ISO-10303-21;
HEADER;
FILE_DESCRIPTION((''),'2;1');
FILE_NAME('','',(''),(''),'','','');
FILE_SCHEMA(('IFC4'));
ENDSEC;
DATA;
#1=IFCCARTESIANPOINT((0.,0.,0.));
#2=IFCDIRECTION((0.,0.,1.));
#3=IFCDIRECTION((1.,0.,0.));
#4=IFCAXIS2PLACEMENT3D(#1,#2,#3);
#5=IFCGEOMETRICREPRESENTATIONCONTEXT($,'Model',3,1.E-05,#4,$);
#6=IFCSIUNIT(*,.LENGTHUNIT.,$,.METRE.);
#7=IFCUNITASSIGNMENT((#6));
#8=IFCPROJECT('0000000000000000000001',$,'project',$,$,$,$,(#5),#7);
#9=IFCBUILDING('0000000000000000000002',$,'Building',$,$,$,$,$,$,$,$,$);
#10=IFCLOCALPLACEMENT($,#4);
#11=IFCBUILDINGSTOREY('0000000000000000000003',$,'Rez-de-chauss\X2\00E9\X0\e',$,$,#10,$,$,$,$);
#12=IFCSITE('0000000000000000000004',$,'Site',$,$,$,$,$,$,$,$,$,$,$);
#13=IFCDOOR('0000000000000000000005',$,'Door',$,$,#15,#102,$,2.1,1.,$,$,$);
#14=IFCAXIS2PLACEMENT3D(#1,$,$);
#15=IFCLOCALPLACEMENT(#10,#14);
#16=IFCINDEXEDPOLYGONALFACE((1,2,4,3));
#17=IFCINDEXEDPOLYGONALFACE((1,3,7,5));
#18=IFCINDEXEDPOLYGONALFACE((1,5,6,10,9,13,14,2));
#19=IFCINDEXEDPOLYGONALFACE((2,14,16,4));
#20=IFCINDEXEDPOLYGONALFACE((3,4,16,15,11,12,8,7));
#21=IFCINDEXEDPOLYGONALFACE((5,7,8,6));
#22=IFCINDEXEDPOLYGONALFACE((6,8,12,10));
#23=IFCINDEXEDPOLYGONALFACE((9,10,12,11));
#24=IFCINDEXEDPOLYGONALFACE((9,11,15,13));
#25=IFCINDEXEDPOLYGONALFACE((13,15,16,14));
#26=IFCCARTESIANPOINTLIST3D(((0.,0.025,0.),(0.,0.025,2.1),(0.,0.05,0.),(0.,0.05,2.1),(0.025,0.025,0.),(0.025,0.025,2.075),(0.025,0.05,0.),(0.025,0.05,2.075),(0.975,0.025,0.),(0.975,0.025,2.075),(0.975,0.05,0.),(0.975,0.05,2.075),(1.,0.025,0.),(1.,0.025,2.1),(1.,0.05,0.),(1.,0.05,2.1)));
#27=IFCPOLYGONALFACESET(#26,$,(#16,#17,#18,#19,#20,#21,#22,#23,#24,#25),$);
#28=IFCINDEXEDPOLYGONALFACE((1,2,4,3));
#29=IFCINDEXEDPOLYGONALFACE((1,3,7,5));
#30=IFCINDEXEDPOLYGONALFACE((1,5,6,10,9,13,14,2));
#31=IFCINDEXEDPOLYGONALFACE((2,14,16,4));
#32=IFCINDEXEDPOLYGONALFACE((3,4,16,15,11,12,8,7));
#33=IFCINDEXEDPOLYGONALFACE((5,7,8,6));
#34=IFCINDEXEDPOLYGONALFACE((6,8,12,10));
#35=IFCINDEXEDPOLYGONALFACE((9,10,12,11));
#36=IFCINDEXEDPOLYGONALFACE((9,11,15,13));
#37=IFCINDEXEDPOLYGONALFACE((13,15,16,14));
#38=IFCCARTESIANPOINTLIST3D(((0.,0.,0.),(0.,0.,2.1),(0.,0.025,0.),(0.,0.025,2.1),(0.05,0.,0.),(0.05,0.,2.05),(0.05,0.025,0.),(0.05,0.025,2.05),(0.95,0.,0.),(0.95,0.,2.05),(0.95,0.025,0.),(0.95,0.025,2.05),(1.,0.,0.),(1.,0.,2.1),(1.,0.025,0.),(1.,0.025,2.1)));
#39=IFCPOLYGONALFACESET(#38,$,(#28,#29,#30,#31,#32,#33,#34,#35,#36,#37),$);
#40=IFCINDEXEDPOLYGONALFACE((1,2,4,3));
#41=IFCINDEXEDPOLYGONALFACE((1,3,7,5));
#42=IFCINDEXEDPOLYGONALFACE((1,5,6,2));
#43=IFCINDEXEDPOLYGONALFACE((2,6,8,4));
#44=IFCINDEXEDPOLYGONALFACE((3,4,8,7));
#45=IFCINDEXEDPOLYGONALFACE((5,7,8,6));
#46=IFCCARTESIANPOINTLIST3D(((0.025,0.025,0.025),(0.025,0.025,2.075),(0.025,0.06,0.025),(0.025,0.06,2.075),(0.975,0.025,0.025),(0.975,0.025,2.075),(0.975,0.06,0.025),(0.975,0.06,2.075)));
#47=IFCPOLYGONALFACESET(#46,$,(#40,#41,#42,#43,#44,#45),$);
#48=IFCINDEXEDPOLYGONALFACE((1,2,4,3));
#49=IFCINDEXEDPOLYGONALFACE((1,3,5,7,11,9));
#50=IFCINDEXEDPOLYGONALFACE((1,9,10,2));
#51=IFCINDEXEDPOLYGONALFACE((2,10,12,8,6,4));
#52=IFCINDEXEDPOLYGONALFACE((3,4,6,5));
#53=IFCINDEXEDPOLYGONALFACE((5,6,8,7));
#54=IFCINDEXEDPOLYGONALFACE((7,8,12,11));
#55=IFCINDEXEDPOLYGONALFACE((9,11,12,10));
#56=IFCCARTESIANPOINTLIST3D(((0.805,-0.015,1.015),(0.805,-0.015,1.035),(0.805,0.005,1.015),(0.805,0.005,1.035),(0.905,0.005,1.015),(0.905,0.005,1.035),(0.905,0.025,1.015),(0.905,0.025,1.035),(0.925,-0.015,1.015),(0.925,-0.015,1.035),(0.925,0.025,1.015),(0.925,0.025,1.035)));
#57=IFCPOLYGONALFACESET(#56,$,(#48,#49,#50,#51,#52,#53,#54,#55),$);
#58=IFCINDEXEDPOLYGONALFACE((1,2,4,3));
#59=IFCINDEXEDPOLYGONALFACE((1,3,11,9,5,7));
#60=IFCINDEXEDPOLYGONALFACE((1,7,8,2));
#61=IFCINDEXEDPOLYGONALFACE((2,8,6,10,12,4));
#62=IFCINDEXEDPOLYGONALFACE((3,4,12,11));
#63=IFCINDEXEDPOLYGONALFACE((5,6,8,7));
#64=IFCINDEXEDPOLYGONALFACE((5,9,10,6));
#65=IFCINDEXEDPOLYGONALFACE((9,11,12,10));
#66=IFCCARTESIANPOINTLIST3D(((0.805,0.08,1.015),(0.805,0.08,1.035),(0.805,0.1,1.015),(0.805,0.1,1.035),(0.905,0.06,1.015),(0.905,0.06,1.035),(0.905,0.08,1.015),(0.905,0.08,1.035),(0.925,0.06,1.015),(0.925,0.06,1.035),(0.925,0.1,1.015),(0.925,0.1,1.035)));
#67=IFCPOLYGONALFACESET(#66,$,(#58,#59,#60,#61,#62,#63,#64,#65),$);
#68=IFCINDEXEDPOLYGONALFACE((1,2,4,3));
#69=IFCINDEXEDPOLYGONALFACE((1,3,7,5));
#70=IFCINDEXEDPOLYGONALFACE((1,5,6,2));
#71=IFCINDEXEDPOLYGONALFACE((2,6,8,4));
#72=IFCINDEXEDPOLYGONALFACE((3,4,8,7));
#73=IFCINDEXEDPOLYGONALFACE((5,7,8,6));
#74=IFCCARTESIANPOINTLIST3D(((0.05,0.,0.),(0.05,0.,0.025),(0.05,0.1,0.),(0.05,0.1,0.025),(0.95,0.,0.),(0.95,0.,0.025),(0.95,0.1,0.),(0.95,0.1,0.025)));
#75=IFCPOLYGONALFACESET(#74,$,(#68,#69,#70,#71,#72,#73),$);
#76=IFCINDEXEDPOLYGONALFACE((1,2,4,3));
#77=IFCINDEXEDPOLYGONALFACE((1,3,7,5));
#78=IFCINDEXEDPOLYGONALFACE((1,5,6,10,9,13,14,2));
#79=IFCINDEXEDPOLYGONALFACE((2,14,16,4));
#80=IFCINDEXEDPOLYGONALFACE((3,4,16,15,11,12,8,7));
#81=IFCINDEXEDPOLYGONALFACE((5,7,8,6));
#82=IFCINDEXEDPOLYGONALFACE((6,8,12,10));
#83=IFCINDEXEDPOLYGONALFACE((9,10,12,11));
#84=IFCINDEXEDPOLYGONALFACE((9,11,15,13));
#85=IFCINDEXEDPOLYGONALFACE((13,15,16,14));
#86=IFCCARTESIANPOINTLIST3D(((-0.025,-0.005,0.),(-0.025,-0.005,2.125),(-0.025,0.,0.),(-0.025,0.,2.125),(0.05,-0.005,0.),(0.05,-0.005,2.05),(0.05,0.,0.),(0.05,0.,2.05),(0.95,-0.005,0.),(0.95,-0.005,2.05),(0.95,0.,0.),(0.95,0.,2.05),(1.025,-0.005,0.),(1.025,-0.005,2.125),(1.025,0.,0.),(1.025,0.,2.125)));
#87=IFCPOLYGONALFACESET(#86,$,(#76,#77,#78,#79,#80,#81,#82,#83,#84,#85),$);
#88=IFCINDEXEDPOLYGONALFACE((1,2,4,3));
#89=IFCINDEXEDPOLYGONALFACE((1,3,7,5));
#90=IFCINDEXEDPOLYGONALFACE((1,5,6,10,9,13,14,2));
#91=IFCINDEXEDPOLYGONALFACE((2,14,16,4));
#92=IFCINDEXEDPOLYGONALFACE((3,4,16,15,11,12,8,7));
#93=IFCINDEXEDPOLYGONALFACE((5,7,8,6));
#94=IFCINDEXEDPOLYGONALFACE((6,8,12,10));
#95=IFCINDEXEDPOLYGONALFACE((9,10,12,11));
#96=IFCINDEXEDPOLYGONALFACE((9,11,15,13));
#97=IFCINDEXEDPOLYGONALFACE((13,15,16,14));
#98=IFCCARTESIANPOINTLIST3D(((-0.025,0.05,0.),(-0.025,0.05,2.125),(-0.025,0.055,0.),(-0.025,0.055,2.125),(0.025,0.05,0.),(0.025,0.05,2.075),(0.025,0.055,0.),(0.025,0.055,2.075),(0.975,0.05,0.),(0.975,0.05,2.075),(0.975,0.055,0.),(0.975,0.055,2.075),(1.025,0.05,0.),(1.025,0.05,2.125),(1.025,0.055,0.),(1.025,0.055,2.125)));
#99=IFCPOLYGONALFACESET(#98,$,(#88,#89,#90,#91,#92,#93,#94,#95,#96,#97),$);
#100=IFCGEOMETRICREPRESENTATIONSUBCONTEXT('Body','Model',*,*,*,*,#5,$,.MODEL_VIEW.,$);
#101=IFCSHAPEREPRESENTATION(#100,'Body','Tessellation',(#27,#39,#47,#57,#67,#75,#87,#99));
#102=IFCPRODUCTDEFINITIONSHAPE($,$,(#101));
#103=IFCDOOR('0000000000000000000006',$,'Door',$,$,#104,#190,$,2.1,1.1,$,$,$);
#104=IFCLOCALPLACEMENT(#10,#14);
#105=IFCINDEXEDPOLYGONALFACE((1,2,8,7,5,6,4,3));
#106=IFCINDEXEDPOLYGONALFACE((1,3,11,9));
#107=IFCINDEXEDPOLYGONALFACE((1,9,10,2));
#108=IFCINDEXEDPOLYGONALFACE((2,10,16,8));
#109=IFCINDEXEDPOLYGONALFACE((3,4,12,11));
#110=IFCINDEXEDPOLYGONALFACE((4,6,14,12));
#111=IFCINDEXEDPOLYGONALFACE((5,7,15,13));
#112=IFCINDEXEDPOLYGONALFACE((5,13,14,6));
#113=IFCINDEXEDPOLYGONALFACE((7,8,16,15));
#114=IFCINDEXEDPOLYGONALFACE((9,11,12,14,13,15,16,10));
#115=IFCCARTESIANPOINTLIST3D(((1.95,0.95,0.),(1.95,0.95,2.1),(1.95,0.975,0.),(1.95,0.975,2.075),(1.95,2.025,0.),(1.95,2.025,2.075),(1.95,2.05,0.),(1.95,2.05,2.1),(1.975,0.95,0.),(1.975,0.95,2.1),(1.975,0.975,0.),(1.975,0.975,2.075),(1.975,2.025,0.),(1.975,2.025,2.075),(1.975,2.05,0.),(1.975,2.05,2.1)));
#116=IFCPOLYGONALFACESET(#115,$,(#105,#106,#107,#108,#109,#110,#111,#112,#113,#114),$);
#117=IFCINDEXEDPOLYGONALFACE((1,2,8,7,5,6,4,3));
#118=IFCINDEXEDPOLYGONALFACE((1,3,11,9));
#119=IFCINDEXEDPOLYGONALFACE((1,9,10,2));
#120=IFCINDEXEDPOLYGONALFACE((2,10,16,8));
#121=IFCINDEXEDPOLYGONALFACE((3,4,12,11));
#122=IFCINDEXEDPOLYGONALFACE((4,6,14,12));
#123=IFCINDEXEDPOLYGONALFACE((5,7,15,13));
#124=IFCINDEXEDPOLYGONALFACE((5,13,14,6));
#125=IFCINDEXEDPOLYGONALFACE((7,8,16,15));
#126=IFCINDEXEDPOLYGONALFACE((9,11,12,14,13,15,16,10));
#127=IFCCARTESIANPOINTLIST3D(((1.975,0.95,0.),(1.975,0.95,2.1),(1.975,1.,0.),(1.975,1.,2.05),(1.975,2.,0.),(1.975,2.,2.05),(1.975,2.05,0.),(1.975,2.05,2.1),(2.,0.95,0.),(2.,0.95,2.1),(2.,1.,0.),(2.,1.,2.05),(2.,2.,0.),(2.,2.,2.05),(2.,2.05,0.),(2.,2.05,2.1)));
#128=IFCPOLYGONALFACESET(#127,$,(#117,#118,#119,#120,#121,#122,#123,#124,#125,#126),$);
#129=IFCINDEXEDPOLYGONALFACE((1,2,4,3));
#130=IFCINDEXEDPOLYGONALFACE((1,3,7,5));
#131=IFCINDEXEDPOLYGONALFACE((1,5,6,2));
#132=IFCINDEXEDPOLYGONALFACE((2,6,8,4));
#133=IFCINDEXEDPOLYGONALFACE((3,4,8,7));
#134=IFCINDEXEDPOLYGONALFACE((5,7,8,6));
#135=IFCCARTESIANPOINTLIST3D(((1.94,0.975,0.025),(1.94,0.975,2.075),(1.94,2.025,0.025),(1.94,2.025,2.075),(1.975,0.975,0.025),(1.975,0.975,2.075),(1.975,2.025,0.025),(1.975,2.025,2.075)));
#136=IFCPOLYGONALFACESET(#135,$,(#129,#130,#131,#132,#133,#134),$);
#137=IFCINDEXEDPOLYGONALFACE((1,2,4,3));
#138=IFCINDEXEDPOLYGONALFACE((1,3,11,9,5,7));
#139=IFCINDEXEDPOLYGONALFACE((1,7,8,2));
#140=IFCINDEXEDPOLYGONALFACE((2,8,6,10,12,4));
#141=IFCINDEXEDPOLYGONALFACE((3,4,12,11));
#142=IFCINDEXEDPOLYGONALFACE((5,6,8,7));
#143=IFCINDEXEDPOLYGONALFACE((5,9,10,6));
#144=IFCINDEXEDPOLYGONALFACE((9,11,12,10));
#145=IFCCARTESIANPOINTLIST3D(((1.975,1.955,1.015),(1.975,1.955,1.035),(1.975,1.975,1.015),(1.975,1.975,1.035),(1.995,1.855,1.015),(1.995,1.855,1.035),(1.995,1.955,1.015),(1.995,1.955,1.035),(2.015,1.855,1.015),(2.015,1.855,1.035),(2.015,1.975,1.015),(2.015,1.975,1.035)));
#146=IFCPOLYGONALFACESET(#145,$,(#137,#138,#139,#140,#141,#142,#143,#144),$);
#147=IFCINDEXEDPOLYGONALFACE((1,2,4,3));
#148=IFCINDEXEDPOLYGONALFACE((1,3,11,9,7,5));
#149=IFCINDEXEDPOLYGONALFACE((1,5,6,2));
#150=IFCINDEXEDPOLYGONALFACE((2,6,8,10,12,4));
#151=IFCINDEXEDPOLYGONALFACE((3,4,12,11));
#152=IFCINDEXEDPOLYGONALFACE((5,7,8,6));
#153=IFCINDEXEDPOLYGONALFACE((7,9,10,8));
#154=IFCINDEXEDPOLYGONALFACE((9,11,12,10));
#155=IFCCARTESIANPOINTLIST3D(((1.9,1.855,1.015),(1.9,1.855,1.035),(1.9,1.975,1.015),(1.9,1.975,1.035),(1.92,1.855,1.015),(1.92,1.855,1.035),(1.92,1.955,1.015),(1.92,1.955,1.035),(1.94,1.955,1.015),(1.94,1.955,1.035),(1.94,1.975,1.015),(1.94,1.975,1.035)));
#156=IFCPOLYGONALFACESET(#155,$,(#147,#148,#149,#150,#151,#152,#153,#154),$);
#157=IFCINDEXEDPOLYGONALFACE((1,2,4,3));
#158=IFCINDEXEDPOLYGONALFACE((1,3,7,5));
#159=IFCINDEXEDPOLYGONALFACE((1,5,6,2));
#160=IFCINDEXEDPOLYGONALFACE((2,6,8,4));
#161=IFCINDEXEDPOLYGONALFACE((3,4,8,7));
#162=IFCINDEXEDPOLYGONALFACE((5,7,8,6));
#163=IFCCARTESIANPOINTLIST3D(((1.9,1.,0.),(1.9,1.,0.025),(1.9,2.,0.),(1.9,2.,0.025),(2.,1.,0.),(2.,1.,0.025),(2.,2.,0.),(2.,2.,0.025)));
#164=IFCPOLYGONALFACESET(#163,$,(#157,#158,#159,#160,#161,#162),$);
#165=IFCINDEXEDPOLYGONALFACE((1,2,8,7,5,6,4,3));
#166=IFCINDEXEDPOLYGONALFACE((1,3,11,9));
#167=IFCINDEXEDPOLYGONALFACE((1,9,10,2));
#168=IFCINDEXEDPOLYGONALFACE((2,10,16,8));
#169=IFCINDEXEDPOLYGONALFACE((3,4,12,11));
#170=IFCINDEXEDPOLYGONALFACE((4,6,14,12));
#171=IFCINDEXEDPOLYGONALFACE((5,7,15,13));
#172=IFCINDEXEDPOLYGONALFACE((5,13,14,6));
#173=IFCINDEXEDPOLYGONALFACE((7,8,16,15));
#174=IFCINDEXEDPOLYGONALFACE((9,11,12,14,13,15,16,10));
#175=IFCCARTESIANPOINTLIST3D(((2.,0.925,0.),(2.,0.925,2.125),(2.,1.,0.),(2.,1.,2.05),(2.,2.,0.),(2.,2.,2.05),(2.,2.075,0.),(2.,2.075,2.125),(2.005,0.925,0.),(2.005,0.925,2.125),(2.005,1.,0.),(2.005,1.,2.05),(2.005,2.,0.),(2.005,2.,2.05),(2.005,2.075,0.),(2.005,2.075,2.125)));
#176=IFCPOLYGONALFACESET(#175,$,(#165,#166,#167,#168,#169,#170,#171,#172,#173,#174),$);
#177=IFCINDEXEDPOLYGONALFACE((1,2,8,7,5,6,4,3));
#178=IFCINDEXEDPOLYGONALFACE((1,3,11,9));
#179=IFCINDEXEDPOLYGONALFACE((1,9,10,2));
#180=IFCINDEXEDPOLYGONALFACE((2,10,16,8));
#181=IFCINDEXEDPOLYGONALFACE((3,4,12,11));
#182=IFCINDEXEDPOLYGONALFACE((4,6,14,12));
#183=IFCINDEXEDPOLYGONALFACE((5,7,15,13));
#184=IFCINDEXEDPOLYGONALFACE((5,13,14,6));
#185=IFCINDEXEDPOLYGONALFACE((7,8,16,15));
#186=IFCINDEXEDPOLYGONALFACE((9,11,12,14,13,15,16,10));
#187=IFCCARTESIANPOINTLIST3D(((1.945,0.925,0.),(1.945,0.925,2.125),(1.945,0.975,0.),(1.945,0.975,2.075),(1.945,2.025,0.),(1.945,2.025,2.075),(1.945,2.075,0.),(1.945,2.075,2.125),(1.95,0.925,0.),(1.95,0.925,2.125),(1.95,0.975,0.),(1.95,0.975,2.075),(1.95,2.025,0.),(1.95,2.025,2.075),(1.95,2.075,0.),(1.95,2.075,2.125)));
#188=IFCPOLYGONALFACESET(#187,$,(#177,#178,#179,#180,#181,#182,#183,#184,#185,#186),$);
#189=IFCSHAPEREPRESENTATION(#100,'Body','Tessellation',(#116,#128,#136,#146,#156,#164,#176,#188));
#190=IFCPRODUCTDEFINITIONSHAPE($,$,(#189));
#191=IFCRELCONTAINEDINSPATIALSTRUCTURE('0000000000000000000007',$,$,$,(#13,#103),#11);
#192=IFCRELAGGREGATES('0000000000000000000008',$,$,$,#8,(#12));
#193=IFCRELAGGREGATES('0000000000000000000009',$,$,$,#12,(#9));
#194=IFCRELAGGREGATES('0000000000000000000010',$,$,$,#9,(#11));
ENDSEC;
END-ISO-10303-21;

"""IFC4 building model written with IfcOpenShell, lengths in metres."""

from ifc_helpers import new_model, si_unit, frame, origin_with_axes, place, context, subcontext, project, spatial, line, indexed_curve, outline, extrude, element, save


model = new_model("IFC4")

# Units and contexts
model_context = context("Model", 3, precision=1e-05, world=origin_with_axes())
body_context = subcontext(model_context, "Body", "Model", "MODEL_VIEW")
ifc_project = project(units=[si_unit("LENGTHUNIT", "METRE")], contexts=[model_context])

# Site, building, storey
site = spatial("IfcSite", under=ifc_project, Name="Site")
building = spatial("IfcBuilding", under=site, Name="Building")
storey_placement = place(None, origin_with_axes())
storey = spatial("IfcBuildingStorey", under=building, at=storey_placement, Name="Rez-de-chaussée")

# Doors
door_1_placement = place(storey_placement, origin_with_axes())
element("IfcDoor", 1, at=door_1_placement, inside=storey, Name="Door", OverallHeight=2.1, OverallWidth=1.0, context=body_context, shape_type="SweptSolid", body=[
    extrude(outline(indexed_curve([(0.0, 0.0), (0.0, 2.1), (1.0, 2.1), (1.0, 0.0), (0.975, 0.0), (0.975, 2.075), (0.025, 2.075), (0.025, 0.0)], segments=[line(1, 2, 3, 4, 5, 6, 7, 8, 1)])), frame((0.0, 0.025, 0.0), z_axis=(0.0, -1.0, 0.0), x_axis=(1.0, 0.0, 0.0)), (0.0, 0.0, -1.0), 0.025),
    extrude(outline(indexed_curve([(0.0, 0.0), (0.0, 2.1), (1.0, 2.1), (1.0, 0.0), (0.95, 0.0), (0.95, 2.05), (0.05, 2.05), (0.05, 0.0)], segments=[line(1, 2, 3, 4, 5, 6, 7, 8, 1)])), frame((0.0, 0.0, 0.0), z_axis=(0.0, -1.0, 0.0), x_axis=(1.0, 0.0, 0.0)), (0.0, 0.0, -1.0), 0.025),
    extrude(outline(indexed_curve([(0.0, 0.0), (0.95, 0.0), (0.95, 0.035), (0.0, 0.035)], segments=[line(1, 2, 3, 4, 1)])), frame((0.025, 0.025, 0.025), z_axis=(0.0, 0.0, 1.0), x_axis=(1.0, 0.0, 0.0)), (0.0, 0.0, 1.0), 2.05),
    extrude(outline(indexed_curve([(0.0, 0.0), (0.0, -0.04), (-0.12, -0.04), (-0.12, -0.02), (-0.02, -0.02), (-0.02, 0.0)], segments=[line(1, 2, 3, 4, 5, 6, 1)])), frame((0.925, 0.025, 1.015), z_axis=(0.0, 0.0, 1.0), x_axis=(1.0, 0.0, 0.0)), (0.0, 0.0, 1.0), 0.02),
    extrude(outline(indexed_curve([(0.0, 0.0), (0.0, 0.04), (-0.12, 0.04), (-0.12, 0.02), (-0.02, 0.02), (-0.02, 0.0)], segments=[line(1, 2, 3, 4, 5, 6, 1)])), frame((0.925, 0.06, 1.015), z_axis=(0.0, 0.0, 1.0), x_axis=(1.0, 0.0, 0.0)), (0.0, 0.0, 1.0), 0.02),
    extrude(outline(indexed_curve([(0.0, 0.0), (0.9, 0.0), (0.9, 0.1), (0.0, 0.1)], segments=[line(1, 2, 3, 4, 1)])), frame((0.05, 0.0, 0.0), z_axis=(0.0, 0.0, 1.0), x_axis=(1.0, 0.0, 0.0)), (0.0, 0.0, 1.0), 0.025),
    extrude(outline(indexed_curve([(0.0, 0.0), (0.0, 2.125), (1.05, 2.125), (1.05, 0.0), (0.975, 0.0), (0.975, 2.05), (0.075, 2.05), (0.075, 0.0)], segments=[line(1, 2, 3, 4, 5, 6, 7, 8, 1)])), frame((-0.025, -0.005, 0.0), z_axis=(0.0, -1.0, 0.0), x_axis=(1.0, 0.0, 0.0)), (0.0, 0.0, -1.0), 0.005),
    extrude(outline(indexed_curve([(0.0, 0.0), (0.0, 2.125), (1.05, 2.125), (1.05, 0.0), (1.0, 0.0), (1.0, 2.075), (0.05, 2.075), (0.05, 0.0)], segments=[line(1, 2, 3, 4, 5, 6, 7, 8, 1)])), frame((-0.025, 0.05, 0.0), z_axis=(0.0, -1.0, 0.0), x_axis=(1.0, 0.0, 0.0)), (0.0, 0.0, -1.0), 0.005),
])
door_2_placement = place(storey_placement, frame((2.0, 0.95, 0.0), z_axis=(0.0, 0.0, 1.0), x_axis=(0.0, 1.0, 0.0)))
element("IfcDoor", 2, at=door_2_placement, inside=storey, Name="Door", OverallHeight=2.1, OverallWidth=1.1, context=body_context, shape_type="SweptSolid", body=[
    extrude(outline(indexed_curve([(0.0, 0.0), (0.0, 2.1), (1.1, 2.1), (1.1, 0.0), (1.075, 0.0), (1.075, 2.075), (0.025, 2.075), (0.025, 0.0)], segments=[line(1, 2, 3, 4, 5, 6, 7, 8, 1)])), frame((0.0, 0.025, 0.0), z_axis=(0.0, -1.0, 0.0), x_axis=(1.0, 0.0, 0.0)), (0.0, 0.0, -1.0), 0.025),
    extrude(outline(indexed_curve([(0.0, 0.0), (0.0, 2.1), (1.1, 2.1), (1.1, 0.0), (1.05, 0.0), (1.05, 2.05), (0.05, 2.05), (0.05, 0.0)], segments=[line(1, 2, 3, 4, 5, 6, 7, 8, 1)])), frame((0.0, 0.0, 0.0), z_axis=(0.0, -1.0, 0.0), x_axis=(1.0, 0.0, 0.0)), (0.0, 0.0, -1.0), 0.025),
    extrude(outline(indexed_curve([(0.0, 0.0), (1.05, 0.0), (1.05, 0.035), (0.0, 0.035)], segments=[line(1, 2, 3, 4, 1)])), frame((0.025, 0.025, 0.025), z_axis=(0.0, 0.0, 1.0), x_axis=(1.0, 0.0, 0.0)), (0.0, 0.0, 1.0), 2.05),
    extrude(outline(indexed_curve([(0.0, 0.0), (0.0, -0.04), (-0.12, -0.04), (-0.12, -0.02), (-0.02, -0.02), (-0.02, 0.0)], segments=[line(1, 2, 3, 4, 5, 6, 1)])), frame((1.025, 0.025, 1.015), z_axis=(0.0, 0.0, 1.0), x_axis=(1.0, 0.0, 0.0)), (0.0, 0.0, 1.0), 0.02),
    extrude(outline(indexed_curve([(0.0, 0.0), (0.0, 0.04), (-0.12, 0.04), (-0.12, 0.02), (-0.02, 0.02), (-0.02, 0.0)], segments=[line(1, 2, 3, 4, 5, 6, 1)])), frame((1.025, 0.06, 1.015), z_axis=(0.0, 0.0, 1.0), x_axis=(1.0, 0.0, 0.0)), (0.0, 0.0, 1.0), 0.02),
    extrude(outline(indexed_curve([(0.0, 0.0), (1.0, 0.0), (1.0, 0.1), (0.0, 0.1)], segments=[line(1, 2, 3, 4, 1)])), frame((0.05, 0.0, 0.0), z_axis=(0.0, 0.0, 1.0), x_axis=(1.0, 0.0, 0.0)), (0.0, 0.0, 1.0), 0.025),
    extrude(outline(indexed_curve([(0.0, 0.0), (0.0, 2.125), (1.15, 2.125), (1.15, 0.0), (1.075, 0.0), (1.075, 2.05), (0.075, 2.05), (0.075, 0.0)], segments=[line(1, 2, 3, 4, 5, 6, 7, 8, 1)])), frame((-0.025, -0.005, 0.0), z_axis=(0.0, -1.0, 0.0), x_axis=(1.0, 0.0, 0.0)), (0.0, 0.0, -1.0), 0.005),
    extrude(outline(indexed_curve([(0.0, 0.0), (0.0, 2.125), (1.15, 2.125), (1.15, 0.0), (1.1, 0.0), (1.1, 2.075), (0.05, 2.075), (0.05, 0.0)], segments=[line(1, 2, 3, 4, 5, 6, 7, 8, 1)])), frame((-0.025, 0.05, 0.0), z_axis=(0.0, -1.0, 0.0), x_axis=(1.0, 0.0, 0.0)), (0.0, 0.0, -1.0), 0.005),
])

save(model, "model.ifc")
